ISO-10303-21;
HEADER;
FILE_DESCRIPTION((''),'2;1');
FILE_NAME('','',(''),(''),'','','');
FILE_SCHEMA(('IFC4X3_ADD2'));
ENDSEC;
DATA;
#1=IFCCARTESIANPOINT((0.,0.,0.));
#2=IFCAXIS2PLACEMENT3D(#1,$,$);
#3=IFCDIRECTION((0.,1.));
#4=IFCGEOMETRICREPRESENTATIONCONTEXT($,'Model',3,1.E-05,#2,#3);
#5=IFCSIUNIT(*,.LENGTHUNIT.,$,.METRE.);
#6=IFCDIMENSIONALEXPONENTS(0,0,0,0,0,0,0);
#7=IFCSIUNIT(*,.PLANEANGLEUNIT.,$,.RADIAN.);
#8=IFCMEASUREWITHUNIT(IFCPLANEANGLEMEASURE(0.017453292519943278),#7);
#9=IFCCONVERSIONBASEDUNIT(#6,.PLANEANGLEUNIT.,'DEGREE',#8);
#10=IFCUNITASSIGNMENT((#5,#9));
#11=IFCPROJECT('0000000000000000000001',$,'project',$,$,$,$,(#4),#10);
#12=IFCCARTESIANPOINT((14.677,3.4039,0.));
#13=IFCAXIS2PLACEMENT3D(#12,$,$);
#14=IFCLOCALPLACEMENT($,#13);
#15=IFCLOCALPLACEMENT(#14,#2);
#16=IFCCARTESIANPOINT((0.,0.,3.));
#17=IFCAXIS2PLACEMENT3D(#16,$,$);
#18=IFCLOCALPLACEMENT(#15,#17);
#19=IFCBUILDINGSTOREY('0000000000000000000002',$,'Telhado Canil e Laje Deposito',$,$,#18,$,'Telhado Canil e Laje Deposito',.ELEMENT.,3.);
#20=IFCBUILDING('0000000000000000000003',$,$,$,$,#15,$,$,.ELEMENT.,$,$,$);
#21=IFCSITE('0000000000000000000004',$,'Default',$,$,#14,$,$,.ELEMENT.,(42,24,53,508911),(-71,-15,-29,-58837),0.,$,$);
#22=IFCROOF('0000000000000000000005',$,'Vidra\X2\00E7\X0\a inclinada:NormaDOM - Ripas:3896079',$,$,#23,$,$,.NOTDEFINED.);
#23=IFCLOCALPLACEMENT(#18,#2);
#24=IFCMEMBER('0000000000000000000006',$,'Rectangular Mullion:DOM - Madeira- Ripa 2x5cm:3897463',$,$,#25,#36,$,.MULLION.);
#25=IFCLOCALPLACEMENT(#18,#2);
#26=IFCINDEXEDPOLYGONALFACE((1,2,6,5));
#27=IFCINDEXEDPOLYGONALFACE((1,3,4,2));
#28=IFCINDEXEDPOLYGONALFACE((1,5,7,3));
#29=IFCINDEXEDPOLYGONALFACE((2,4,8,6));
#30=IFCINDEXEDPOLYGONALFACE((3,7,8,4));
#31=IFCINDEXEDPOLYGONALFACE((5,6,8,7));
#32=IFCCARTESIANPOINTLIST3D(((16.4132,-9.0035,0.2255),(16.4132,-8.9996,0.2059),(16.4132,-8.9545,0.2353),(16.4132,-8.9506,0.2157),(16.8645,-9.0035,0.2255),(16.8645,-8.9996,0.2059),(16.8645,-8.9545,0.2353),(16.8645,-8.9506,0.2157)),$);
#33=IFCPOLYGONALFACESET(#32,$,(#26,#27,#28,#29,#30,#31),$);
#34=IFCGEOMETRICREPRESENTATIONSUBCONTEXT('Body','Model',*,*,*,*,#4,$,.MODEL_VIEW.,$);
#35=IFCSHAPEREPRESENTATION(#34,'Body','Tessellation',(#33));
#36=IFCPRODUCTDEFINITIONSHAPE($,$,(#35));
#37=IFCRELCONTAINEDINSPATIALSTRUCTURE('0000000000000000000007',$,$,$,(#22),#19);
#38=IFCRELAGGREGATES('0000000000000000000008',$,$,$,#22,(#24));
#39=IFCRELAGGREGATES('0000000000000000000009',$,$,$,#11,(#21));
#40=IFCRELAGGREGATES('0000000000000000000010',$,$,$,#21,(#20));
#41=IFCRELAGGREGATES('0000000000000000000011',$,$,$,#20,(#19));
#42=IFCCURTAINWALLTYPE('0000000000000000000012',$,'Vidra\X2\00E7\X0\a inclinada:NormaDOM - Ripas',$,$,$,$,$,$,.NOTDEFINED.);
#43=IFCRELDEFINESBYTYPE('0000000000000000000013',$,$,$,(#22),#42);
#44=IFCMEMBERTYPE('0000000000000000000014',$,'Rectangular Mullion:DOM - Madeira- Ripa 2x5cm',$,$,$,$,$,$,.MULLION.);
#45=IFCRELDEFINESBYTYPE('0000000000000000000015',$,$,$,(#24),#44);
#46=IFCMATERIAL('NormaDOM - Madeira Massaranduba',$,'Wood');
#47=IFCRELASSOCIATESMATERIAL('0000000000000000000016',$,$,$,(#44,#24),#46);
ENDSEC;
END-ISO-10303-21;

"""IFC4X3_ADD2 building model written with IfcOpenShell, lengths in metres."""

from ifc_helpers import new_model, entity, si_unit, converted_unit, direction, frame, origin, origin_2d_with_axis, place, context, subcontext, project, spatial, rectangle, extrude, source, transform, mapped, material, material_profile, profile_set, profile_usage, type_object, type_shapes, element, aggregate, save


model = new_model("IFC4X3_ADD2")

# Units and contexts
model_context = context("Model", 3, precision=1e-05, world=origin(), true_north=direction((0.0, 1.0)))
body_context = subcontext(model_context, "Body", "Model", "MODEL_VIEW")
ifc_project = project(units=[si_unit("LENGTHUNIT", "METRE"), converted_unit("PLANEANGLEUNIT", "DEGREE", entity("IfcPlaneAngleMeasure", 0.017453292519943278), si_unit("PLANEANGLEUNIT", "RADIAN"), dimensions=[0, 0, 0, 0, 0, 0, 0])], contexts=[model_context])

# Site, building, storey
site_placement = place(None, frame((14.677, 3.4039, 0.0)))
site = spatial("IfcSite", under=ifc_project, at=site_placement, Name="Default", CompositionType="ELEMENT", RefLatitude=(42, 24, 53, 508911), RefLongitude=(-71, -15, -29, -58837), RefElevation=0.0)
building_placement = place(site_placement, origin())
building = spatial("IfcBuilding", under=site, at=building_placement, CompositionType="ELEMENT")
storey_placement = place(building_placement, frame((0.0, 0.0, 3.0)))
storey = spatial("IfcBuildingStorey", under=building, at=storey_placement, Name="Telhado Canil e Laje Deposito", LongName="Telhado Canil e Laje Deposito", CompositionType="ELEMENT", Elevation=3.0)

# Shared definitions
ifc_material = material(Name="NormaDOM - Madeira Massaranduba", Category="Wood")

# Roof, member
ifc_material_profile_1 = material_profile(ifc_material, rectangle(XDim=0.05, YDim=0.02, at=origin_2d_with_axis()), Name="DOM - Madeira- Ripa 2x5cm")
ifc_profile_set_1 = profile_set([ifc_material_profile_1], Name="DOM - Madeira- Ripa 2x5cm")
ifc_profile_usage_1 = profile_usage(ifc_profile_set_1)
curtain_wall_type_1 = type_object("IfcCurtainWallType", Name="Vidraça inclinada:NormaDOM - Ripas", PredefinedType="NOTDEFINED")
roof_1_placement = place(storey_placement, frame((0.0, 0.0, -3.0)))
roof_1 = element("IfcRoof", 1, at=roof_1_placement, inside=storey, type_object=curtain_wall_type_1, Name="Vidraça inclinada:NormaDOM - Ripas:3896079", PredefinedType="NOTDEFINED")
member_type_1 = type_object("IfcMemberType", Name="Rectangular Mullion:DOM - Madeira- Ripa 2x5cm", PredefinedType="MULLION", material=ifc_profile_set_1)
shared_shape_1 = source(origin(), body_context, "Body", "SweptSolid", [
    extrude(rectangle(XDim=0.05, YDim=0.02, at=origin_2d_with_axis()), frame((0.025, 0.01, -0.4514), z_axis=(0.0, 0.0, 1.0), x_axis=(-1.0, 0.0, 0.0)), (0.0, 0.0, 1.0), 0.4514),
])
type_shapes(member_type_1, [shared_shape_1])
member_1_placement = place(roof_1_placement, frame((16.4132, -9.0035, 3.2255), z_axis=(-1.0, 0.0, 0.0), x_axis=(0.0, 0.980581, 0.196116)))
member_1 = element("IfcMember", 2, at=member_1_placement, type_object=member_type_1, material=ifc_profile_usage_1, Name="Rectangular Mullion:DOM - Madeira- Ripa 2x5cm:3897463", PredefinedType="MULLION", context=body_context, shape_type="MappedRepresentation", body=[
    mapped(shared_shape_1, transform((0.0, 0.0, 0.0), scale=1.0)),
])
aggregate(roof_1, [member_1])

save(model, "model.ifc")
